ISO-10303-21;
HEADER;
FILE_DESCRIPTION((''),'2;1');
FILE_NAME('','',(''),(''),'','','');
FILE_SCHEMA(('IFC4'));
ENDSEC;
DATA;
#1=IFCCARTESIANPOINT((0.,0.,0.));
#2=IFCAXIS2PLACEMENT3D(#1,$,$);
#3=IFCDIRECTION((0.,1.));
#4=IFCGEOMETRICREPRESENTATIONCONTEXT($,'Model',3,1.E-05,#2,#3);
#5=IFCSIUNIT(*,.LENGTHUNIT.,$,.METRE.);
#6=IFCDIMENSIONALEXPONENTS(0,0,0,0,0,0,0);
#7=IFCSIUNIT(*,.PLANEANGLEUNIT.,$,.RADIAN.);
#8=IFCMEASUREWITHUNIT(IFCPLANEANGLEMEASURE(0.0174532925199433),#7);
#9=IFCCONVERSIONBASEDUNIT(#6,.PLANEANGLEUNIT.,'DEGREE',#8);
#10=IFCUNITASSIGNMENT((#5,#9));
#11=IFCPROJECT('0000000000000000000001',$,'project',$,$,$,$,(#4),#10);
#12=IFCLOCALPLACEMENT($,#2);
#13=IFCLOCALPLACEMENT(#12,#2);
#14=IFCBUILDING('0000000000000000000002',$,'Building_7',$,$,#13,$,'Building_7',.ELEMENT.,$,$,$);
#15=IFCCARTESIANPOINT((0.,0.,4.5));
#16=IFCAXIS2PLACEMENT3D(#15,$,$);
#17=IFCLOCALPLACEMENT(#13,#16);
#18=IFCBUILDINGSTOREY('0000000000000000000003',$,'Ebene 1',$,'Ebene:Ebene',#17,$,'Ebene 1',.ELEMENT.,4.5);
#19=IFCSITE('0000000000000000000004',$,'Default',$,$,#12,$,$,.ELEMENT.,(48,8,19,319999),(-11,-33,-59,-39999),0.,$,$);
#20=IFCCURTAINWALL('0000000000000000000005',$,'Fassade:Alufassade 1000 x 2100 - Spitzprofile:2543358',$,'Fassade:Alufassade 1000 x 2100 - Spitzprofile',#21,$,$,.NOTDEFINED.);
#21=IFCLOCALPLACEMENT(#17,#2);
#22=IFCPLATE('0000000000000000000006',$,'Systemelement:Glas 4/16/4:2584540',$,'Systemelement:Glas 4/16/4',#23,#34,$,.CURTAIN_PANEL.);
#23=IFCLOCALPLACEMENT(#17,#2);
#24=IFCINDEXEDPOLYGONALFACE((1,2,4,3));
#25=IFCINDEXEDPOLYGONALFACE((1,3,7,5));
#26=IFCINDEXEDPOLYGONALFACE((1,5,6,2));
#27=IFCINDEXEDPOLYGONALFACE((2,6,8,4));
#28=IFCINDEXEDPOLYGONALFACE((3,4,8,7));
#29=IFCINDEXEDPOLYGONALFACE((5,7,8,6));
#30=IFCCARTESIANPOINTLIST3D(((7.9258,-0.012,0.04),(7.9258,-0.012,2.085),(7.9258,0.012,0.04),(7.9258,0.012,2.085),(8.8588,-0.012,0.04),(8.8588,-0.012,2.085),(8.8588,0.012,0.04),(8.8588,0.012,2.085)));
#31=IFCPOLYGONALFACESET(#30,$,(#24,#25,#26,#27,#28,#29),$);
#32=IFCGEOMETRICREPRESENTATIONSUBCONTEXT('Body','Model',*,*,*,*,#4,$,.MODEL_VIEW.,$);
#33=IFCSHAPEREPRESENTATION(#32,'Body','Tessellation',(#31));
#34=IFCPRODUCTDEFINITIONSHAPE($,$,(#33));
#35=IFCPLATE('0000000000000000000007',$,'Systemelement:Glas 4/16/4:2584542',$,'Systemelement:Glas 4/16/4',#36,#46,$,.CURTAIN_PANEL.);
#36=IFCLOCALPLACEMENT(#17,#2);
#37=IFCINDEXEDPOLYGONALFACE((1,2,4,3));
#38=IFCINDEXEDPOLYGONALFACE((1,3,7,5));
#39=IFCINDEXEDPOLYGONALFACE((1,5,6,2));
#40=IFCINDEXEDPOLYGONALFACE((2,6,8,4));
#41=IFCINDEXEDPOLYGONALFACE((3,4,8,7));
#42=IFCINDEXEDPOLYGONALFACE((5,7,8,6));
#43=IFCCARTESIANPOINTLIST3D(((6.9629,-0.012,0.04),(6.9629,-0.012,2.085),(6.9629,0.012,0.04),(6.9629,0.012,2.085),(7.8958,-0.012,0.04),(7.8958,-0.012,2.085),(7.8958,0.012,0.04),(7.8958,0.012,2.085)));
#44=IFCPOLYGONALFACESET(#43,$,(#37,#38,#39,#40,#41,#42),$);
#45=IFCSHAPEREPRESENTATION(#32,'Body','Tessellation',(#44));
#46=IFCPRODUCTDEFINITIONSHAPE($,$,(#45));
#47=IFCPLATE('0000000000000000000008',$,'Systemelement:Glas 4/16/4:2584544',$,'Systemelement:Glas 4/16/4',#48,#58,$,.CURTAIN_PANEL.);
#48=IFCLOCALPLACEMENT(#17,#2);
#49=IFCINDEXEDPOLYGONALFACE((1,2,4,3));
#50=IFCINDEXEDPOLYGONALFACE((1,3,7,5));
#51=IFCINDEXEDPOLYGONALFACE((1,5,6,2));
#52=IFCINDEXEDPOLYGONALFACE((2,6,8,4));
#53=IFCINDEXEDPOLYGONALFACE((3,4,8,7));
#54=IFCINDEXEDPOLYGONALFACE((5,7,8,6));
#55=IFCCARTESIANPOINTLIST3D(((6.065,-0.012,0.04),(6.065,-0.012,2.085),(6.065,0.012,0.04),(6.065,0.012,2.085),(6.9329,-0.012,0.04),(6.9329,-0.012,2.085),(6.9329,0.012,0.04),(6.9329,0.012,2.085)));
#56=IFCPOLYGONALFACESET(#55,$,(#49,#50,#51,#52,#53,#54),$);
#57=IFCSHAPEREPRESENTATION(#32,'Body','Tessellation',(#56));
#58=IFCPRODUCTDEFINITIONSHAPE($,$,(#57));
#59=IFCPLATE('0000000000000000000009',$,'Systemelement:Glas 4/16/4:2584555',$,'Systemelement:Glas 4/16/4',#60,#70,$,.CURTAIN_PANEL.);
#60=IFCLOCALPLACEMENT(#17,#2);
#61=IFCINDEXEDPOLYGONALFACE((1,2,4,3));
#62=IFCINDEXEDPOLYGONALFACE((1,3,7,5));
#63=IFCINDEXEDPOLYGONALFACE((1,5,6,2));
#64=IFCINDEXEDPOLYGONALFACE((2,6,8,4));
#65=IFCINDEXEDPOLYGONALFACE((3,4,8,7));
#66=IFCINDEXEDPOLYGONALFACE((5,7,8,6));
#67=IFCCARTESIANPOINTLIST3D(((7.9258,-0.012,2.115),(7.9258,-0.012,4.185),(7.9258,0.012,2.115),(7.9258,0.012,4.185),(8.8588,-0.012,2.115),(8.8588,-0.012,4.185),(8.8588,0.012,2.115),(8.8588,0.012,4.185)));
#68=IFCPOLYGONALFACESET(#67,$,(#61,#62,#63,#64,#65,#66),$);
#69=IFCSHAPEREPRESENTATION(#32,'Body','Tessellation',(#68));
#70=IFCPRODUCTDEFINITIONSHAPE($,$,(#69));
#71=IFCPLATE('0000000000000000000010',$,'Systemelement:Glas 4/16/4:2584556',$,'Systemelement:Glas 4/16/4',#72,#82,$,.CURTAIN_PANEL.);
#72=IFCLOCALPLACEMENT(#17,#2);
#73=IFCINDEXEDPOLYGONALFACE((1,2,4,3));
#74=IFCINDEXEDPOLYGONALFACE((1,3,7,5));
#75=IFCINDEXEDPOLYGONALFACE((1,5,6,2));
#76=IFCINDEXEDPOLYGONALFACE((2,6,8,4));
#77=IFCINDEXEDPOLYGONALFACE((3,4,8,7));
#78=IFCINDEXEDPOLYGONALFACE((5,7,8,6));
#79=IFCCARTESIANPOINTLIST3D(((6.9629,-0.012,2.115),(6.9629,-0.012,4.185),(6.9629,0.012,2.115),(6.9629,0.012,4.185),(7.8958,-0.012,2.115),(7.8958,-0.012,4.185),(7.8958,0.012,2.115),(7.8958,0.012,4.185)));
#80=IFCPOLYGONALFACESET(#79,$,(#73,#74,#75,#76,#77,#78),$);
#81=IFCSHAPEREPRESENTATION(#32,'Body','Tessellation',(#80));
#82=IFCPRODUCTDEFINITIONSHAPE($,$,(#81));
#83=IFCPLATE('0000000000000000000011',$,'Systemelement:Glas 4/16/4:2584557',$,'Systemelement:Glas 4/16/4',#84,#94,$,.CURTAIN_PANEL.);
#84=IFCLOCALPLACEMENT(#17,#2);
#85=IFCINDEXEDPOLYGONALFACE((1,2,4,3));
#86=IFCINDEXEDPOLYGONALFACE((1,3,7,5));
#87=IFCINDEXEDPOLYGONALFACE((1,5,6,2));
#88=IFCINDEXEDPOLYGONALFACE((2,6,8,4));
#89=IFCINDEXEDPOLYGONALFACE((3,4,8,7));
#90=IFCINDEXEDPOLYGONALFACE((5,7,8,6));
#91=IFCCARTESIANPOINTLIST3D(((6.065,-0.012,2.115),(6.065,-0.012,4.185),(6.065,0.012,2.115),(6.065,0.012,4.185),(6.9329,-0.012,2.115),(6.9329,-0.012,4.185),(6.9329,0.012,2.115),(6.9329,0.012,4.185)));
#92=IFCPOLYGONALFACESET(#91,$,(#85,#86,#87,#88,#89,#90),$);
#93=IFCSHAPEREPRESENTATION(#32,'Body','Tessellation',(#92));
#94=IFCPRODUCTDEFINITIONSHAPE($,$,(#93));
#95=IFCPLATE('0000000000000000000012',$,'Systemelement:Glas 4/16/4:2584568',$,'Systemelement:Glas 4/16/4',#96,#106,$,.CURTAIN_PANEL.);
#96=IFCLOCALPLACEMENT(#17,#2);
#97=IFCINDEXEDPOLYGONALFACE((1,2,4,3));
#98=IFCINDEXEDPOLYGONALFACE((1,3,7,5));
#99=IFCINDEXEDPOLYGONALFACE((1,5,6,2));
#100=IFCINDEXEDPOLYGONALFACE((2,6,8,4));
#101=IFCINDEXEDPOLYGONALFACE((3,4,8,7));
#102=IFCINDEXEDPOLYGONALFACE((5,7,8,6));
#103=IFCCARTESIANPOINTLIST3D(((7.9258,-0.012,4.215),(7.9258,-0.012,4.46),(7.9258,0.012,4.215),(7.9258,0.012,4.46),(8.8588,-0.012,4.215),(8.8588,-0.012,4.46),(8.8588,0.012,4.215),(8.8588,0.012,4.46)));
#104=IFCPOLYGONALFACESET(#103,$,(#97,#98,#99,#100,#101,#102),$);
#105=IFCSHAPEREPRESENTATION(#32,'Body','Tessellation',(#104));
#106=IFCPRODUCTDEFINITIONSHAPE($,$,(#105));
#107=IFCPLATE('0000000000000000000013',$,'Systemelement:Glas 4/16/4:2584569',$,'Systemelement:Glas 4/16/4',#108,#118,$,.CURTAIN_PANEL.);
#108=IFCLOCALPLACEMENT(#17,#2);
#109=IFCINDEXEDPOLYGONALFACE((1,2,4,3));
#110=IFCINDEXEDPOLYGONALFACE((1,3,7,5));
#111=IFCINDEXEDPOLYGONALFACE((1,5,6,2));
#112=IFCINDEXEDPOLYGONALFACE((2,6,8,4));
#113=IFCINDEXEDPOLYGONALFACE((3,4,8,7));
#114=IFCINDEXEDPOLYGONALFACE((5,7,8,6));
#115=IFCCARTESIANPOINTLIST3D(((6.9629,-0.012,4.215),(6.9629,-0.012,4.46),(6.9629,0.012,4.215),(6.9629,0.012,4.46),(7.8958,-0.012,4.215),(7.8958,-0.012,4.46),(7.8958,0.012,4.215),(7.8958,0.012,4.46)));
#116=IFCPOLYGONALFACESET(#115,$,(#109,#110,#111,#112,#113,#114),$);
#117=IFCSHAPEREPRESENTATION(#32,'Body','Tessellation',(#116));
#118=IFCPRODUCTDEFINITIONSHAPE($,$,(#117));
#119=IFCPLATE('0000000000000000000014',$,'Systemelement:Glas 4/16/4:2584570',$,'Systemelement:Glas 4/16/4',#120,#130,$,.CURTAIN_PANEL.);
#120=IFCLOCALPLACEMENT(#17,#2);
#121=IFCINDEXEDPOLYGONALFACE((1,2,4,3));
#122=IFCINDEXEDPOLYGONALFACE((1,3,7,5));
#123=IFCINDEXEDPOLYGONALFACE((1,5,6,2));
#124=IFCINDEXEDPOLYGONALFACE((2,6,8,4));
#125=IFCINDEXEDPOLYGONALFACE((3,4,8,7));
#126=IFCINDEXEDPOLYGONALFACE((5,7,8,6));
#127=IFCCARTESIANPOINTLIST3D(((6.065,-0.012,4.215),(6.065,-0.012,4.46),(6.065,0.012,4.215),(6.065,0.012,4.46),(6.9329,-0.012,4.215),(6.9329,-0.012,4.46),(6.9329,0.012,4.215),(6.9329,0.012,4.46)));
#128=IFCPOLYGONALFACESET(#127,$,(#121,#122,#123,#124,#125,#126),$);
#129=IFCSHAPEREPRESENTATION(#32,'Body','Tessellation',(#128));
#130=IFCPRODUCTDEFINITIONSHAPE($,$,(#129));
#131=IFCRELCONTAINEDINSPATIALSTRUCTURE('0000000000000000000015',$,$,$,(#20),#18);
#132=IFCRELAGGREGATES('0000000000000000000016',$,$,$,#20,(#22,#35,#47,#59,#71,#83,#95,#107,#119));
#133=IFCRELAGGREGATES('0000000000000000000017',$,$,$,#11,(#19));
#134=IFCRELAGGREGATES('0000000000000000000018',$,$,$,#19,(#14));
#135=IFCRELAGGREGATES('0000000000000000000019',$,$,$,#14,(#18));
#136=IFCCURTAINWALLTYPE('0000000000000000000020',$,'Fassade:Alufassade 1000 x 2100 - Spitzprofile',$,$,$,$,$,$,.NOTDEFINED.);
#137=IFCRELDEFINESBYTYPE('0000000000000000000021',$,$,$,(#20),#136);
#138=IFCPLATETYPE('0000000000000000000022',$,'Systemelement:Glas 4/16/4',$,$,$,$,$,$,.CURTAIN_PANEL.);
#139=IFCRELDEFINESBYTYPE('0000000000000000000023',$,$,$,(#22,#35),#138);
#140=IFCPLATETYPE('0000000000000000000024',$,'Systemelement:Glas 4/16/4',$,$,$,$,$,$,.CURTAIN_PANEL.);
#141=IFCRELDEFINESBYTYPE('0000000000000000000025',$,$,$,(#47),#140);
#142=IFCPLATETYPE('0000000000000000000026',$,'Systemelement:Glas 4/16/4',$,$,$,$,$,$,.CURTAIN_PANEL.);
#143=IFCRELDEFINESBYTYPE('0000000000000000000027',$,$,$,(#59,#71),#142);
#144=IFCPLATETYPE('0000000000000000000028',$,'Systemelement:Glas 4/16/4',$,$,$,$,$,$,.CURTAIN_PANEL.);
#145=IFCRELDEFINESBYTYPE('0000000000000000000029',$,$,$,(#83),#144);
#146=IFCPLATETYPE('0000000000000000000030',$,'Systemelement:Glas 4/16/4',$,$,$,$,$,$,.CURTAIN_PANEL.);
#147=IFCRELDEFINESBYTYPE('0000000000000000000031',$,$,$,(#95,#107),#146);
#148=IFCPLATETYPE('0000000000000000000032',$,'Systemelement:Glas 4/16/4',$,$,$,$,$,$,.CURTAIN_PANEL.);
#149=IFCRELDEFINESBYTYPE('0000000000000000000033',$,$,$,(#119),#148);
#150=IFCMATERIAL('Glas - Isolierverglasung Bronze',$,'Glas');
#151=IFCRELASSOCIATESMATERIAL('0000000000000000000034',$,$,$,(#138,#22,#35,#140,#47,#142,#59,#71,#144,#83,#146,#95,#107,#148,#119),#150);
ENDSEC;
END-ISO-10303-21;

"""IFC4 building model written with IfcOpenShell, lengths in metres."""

from ifc_helpers import new_model, entity, si_unit, converted_unit, direction, frame, origin, place, context, subcontext, project, spatial, indexed_curve, outline, extrude, source, transform, mapped, material, type_object, type_shapes, element, aggregate, save


model = new_model("IFC4")

# Units and contexts
model_context = context("Model", 3, precision=1e-05, world=origin(), true_north=direction((0.0, 1.0)))
body_context = subcontext(model_context, "Body", "Model", "MODEL_VIEW")
ifc_project = project(units=[si_unit("LENGTHUNIT", "METRE"), converted_unit("PLANEANGLEUNIT", "DEGREE", entity("IfcPlaneAngleMeasure", 0.0174532925199433), si_unit("PLANEANGLEUNIT", "RADIAN"), dimensions=[0, 0, 0, 0, 0, 0, 0])], contexts=[model_context])

# Site, building, storey
site_placement = place(None, origin())
site = spatial("IfcSite", under=ifc_project, at=site_placement, Name="Default", CompositionType="ELEMENT", RefLatitude=(48, 8, 19, 319999), RefLongitude=(-11, -33, -59, -39999), RefElevation=0.0)
building_placement = place(site_placement, origin())
building = spatial("IfcBuilding", under=site, at=building_placement, Name="Building_7", LongName="Building_7", CompositionType="ELEMENT")
storey_placement = place(building_placement, frame((0.0, 0.0, 4.5)))
storey = spatial("IfcBuildingStorey", under=building, at=storey_placement, Name="Ebene 1", ObjectType="Ebene:Ebene", LongName="Ebene 1", CompositionType="ELEMENT", Elevation=4.5)

# Curtain wall
curtain_wall_type = type_object("IfcCurtainWallType", Name="Fassade:Alufassade 1000 x 2100 - Spitzprofile", PredefinedType="NOTDEFINED")
curtain_wall_1_placement = place(storey_placement, frame((0.0, 0.0, -4.5)))
curtain_wall_1 = element("IfcCurtainWall", 1, at=curtain_wall_1_placement, inside=storey, type_object=curtain_wall_type, Name="Fassade:Alufassade 1000 x 2100 - Spitzprofile:2543358", ObjectType="Fassade:Alufassade 1000 x 2100 - Spitzprofile", PredefinedType="NOTDEFINED")

# Plates
ifc_material_1 = material(Name="Glas - Isolierverglasung Bronze", Category="Glas")
plate_type_1 = type_object("IfcPlateType", Name="Systemelement:Glas 4/16/4", PredefinedType="CURTAIN_PANEL", material=ifc_material_1)
shared_shape_1 = source(origin(), body_context, "Body", "SweptSolid", [
    extrude(outline(indexed_curve([(-0.012, -0.4665), (0.012, -0.4665), (0.012, 0.4665), (-0.012, 0.4665), (-0.012, -0.4665)], self_intersect=False)), frame((0.0, 0.0, 0.0), z_axis=(0.0, 0.0, 1.0), x_axis=(0.0, 1.0, 0.0)), (0.0, 0.0, 1.0), 2.045),
])
type_shapes(plate_type_1, [shared_shape_1])
plate_1_placement = place(curtain_wall_1_placement, frame((8.3923, 0.0, 4.54), z_axis=(0.0, 0.0, 1.0), x_axis=(-1.0, 0.0, 0.0)))
plate_1 = element("IfcPlate", 2, at=plate_1_placement, type_object=plate_type_1, material=ifc_material_1, Name="Systemelement:Glas 4/16/4:2584540", ObjectType="Systemelement:Glas 4/16/4", PredefinedType="CURTAIN_PANEL", context=body_context, shape_type="MappedRepresentation", body=[
    mapped(shared_shape_1, transform((0.0, 0.0, 0.0), scale=1.0)),
])
plate_2_placement = place(curtain_wall_1_placement, frame((7.4294, 0.0, 4.54), z_axis=(0.0, 0.0, 1.0), x_axis=(-1.0, 0.0, 0.0)))
plate_2 = element("IfcPlate", 3, at=plate_2_placement, type_object=plate_type_1, material=ifc_material_1, Name="Systemelement:Glas 4/16/4:2584542", ObjectType="Systemelement:Glas 4/16/4", PredefinedType="CURTAIN_PANEL", context=body_context, shape_type="MappedRepresentation", body=[
    mapped(shared_shape_1, transform((0.0, 0.0, 0.0), scale=1.0)),
])
plate_type_2 = type_object("IfcPlateType", Name="Systemelement:Glas 4/16/4", PredefinedType="CURTAIN_PANEL", material=ifc_material_1)
shared_shape_2 = source(origin(), body_context, "Body", "SweptSolid", [
    extrude(outline(indexed_curve([(-0.012, -0.434), (0.012, -0.434), (0.012, 0.434), (-0.012, 0.434), (-0.012, -0.434)], self_intersect=False)), frame((0.0, 0.0, 0.0), z_axis=(0.0, 0.0, 1.0), x_axis=(0.0, 1.0, 0.0)), (0.0, 0.0, 1.0), 2.045),
])
type_shapes(plate_type_2, [shared_shape_2])
plate_3_placement = place(curtain_wall_1_placement, frame((6.499, 0.0, 4.54), z_axis=(0.0, 0.0, 1.0), x_axis=(-1.0, 0.0, 0.0)))
plate_3 = element("IfcPlate", 4, at=plate_3_placement, type_object=plate_type_2, material=ifc_material_1, Name="Systemelement:Glas 4/16/4:2584544", ObjectType="Systemelement:Glas 4/16/4", PredefinedType="CURTAIN_PANEL", context=body_context, shape_type="MappedRepresentation", body=[
    mapped(shared_shape_2, transform((0.0, 0.0, 0.0), scale=1.0)),
])
plate_type_3 = type_object("IfcPlateType", Name="Systemelement:Glas 4/16/4", PredefinedType="CURTAIN_PANEL", material=ifc_material_1)
shared_shape_3 = source(origin(), body_context, "Body", "SweptSolid", [
    extrude(outline(indexed_curve([(-0.012, -0.4665), (0.012, -0.4665), (0.012, 0.4665), (-0.012, 0.4665), (-0.012, -0.4665)], self_intersect=False)), frame((0.0, 0.0, 0.0), z_axis=(0.0, 0.0, 1.0), x_axis=(0.0, 1.0, 0.0)), (0.0, 0.0, 1.0), 2.07),
])
type_shapes(plate_type_3, [shared_shape_3])
plate_4_placement = place(curtain_wall_1_placement, frame((8.3923, 0.0, 6.615), z_axis=(0.0, 0.0, 1.0), x_axis=(-1.0, 0.0, 0.0)))
plate_4 = element("IfcPlate", 5, at=plate_4_placement, type_object=plate_type_3, material=ifc_material_1, Name="Systemelement:Glas 4/16/4:2584555", ObjectType="Systemelement:Glas 4/16/4", PredefinedType="CURTAIN_PANEL", context=body_context, shape_type="MappedRepresentation", body=[
    mapped(shared_shape_3, transform((0.0, 0.0, 0.0), scale=1.0)),
])
plate_5_placement = place(curtain_wall_1_placement, frame((7.4294, 0.0, 6.615), z_axis=(0.0, 0.0, 1.0), x_axis=(-1.0, 0.0, 0.0)))
plate_5 = element("IfcPlate", 6, at=plate_5_placement, type_object=plate_type_3, material=ifc_material_1, Name="Systemelement:Glas 4/16/4:2584556", ObjectType="Systemelement:Glas 4/16/4", PredefinedType="CURTAIN_PANEL", context=body_context, shape_type="MappedRepresentation", body=[
    mapped(shared_shape_3, transform((0.0, 0.0, 0.0), scale=1.0)),
])
plate_type_4 = type_object("IfcPlateType", Name="Systemelement:Glas 4/16/4", PredefinedType="CURTAIN_PANEL", material=ifc_material_1)
shared_shape_4 = source(origin(), body_context, "Body", "SweptSolid", [
    extrude(outline(indexed_curve([(-0.012, -0.434), (0.012, -0.434), (0.012, 0.434), (-0.012, 0.434), (-0.012, -0.434)], self_intersect=False)), frame((0.0, 0.0, 0.0), z_axis=(0.0, 0.0, 1.0), x_axis=(0.0, 1.0, 0.0)), (0.0, 0.0, 1.0), 2.07),
])
type_shapes(plate_type_4, [shared_shape_4])
plate_6_placement = place(curtain_wall_1_placement, frame((6.499, 0.0, 6.615), z_axis=(0.0, 0.0, 1.0), x_axis=(-1.0, 0.0, 0.0)))
plate_6 = element("IfcPlate", 7, at=plate_6_placement, type_object=plate_type_4, material=ifc_material_1, Name="Systemelement:Glas 4/16/4:2584557", ObjectType="Systemelement:Glas 4/16/4", PredefinedType="CURTAIN_PANEL", context=body_context, shape_type="MappedRepresentation", body=[
    mapped(shared_shape_4, transform((0.0, 0.0, 0.0), scale=1.0)),
])
plate_type_5 = type_object("IfcPlateType", Name="Systemelement:Glas 4/16/4", PredefinedType="CURTAIN_PANEL", material=ifc_material_1)
shared_shape_5 = source(origin(), body_context, "Body", "SweptSolid", [
    extrude(outline(indexed_curve([(-0.012, -0.4665), (0.012, -0.4665), (0.012, 0.4665), (-0.012, 0.4665), (-0.012, -0.4665)], self_intersect=False)), frame((0.0, 0.0, 0.0), z_axis=(0.0, 0.0, 1.0), x_axis=(0.0, 1.0, 0.0)), (0.0, 0.0, 1.0), 0.245),
])
type_shapes(plate_type_5, [shared_shape_5])
plate_7_placement = place(curtain_wall_1_placement, frame((8.3923, 0.0, 8.715), z_axis=(0.0, 0.0, 1.0), x_axis=(-1.0, 0.0, 0.0)))
plate_7 = element("IfcPlate", 8, at=plate_7_placement, type_object=plate_type_5, material=ifc_material_1, Name="Systemelement:Glas 4/16/4:2584568", ObjectType="Systemelement:Glas 4/16/4", PredefinedType="CURTAIN_PANEL", context=body_context, shape_type="MappedRepresentation", body=[
    mapped(shared_shape_5, transform((0.0, 0.0, 0.0), scale=1.0)),
])
plate_8_placement = place(curtain_wall_1_placement, frame((7.4294, 0.0, 8.715), z_axis=(0.0, 0.0, 1.0), x_axis=(-1.0, 0.0, 0.0)))
plate_8 = element("IfcPlate", 9, at=plate_8_placement, type_object=plate_type_5, material=ifc_material_1, Name="Systemelement:Glas 4/16/4:2584569", ObjectType="Systemelement:Glas 4/16/4", PredefinedType="CURTAIN_PANEL", context=body_context, shape_type="MappedRepresentation", body=[
    mapped(shared_shape_5, transform((0.0, 0.0, 0.0), scale=1.0)),
])
plate_type_6 = type_object("IfcPlateType", Name="Systemelement:Glas 4/16/4", PredefinedType="CURTAIN_PANEL", material=ifc_material_1)
shared_shape_6 = source(origin(), body_context, "Body", "SweptSolid", [
    extrude(outline(indexed_curve([(-0.012, -0.434), (0.012, -0.434), (0.012, 0.434), (-0.012, 0.434), (-0.012, -0.434)], self_intersect=False)), frame((0.0, 0.0, 0.0), z_axis=(0.0, 0.0, 1.0), x_axis=(0.0, 1.0, 0.0)), (0.0, 0.0, 1.0), 0.245),
])
type_shapes(plate_type_6, [shared_shape_6])
plate_9_placement = place(curtain_wall_1_placement, frame((6.499, 0.0, 8.715), z_axis=(0.0, 0.0, 1.0), x_axis=(-1.0, 0.0, 0.0)))
plate_9 = element("IfcPlate", 10, at=plate_9_placement, type_object=plate_type_6, material=ifc_material_1, Name="Systemelement:Glas 4/16/4:2584570", ObjectType="Systemelement:Glas 4/16/4", PredefinedType="CURTAIN_PANEL", context=body_context, shape_type="MappedRepresentation", body=[
    mapped(shared_shape_6, transform((0.0, 0.0, 0.0), scale=1.0)),
])
aggregate(curtain_wall_1, [plate_1, plate_2, plate_3, plate_4, plate_5, plate_6, plate_7, plate_8, plate_9])

save(model, "model.ifc")
